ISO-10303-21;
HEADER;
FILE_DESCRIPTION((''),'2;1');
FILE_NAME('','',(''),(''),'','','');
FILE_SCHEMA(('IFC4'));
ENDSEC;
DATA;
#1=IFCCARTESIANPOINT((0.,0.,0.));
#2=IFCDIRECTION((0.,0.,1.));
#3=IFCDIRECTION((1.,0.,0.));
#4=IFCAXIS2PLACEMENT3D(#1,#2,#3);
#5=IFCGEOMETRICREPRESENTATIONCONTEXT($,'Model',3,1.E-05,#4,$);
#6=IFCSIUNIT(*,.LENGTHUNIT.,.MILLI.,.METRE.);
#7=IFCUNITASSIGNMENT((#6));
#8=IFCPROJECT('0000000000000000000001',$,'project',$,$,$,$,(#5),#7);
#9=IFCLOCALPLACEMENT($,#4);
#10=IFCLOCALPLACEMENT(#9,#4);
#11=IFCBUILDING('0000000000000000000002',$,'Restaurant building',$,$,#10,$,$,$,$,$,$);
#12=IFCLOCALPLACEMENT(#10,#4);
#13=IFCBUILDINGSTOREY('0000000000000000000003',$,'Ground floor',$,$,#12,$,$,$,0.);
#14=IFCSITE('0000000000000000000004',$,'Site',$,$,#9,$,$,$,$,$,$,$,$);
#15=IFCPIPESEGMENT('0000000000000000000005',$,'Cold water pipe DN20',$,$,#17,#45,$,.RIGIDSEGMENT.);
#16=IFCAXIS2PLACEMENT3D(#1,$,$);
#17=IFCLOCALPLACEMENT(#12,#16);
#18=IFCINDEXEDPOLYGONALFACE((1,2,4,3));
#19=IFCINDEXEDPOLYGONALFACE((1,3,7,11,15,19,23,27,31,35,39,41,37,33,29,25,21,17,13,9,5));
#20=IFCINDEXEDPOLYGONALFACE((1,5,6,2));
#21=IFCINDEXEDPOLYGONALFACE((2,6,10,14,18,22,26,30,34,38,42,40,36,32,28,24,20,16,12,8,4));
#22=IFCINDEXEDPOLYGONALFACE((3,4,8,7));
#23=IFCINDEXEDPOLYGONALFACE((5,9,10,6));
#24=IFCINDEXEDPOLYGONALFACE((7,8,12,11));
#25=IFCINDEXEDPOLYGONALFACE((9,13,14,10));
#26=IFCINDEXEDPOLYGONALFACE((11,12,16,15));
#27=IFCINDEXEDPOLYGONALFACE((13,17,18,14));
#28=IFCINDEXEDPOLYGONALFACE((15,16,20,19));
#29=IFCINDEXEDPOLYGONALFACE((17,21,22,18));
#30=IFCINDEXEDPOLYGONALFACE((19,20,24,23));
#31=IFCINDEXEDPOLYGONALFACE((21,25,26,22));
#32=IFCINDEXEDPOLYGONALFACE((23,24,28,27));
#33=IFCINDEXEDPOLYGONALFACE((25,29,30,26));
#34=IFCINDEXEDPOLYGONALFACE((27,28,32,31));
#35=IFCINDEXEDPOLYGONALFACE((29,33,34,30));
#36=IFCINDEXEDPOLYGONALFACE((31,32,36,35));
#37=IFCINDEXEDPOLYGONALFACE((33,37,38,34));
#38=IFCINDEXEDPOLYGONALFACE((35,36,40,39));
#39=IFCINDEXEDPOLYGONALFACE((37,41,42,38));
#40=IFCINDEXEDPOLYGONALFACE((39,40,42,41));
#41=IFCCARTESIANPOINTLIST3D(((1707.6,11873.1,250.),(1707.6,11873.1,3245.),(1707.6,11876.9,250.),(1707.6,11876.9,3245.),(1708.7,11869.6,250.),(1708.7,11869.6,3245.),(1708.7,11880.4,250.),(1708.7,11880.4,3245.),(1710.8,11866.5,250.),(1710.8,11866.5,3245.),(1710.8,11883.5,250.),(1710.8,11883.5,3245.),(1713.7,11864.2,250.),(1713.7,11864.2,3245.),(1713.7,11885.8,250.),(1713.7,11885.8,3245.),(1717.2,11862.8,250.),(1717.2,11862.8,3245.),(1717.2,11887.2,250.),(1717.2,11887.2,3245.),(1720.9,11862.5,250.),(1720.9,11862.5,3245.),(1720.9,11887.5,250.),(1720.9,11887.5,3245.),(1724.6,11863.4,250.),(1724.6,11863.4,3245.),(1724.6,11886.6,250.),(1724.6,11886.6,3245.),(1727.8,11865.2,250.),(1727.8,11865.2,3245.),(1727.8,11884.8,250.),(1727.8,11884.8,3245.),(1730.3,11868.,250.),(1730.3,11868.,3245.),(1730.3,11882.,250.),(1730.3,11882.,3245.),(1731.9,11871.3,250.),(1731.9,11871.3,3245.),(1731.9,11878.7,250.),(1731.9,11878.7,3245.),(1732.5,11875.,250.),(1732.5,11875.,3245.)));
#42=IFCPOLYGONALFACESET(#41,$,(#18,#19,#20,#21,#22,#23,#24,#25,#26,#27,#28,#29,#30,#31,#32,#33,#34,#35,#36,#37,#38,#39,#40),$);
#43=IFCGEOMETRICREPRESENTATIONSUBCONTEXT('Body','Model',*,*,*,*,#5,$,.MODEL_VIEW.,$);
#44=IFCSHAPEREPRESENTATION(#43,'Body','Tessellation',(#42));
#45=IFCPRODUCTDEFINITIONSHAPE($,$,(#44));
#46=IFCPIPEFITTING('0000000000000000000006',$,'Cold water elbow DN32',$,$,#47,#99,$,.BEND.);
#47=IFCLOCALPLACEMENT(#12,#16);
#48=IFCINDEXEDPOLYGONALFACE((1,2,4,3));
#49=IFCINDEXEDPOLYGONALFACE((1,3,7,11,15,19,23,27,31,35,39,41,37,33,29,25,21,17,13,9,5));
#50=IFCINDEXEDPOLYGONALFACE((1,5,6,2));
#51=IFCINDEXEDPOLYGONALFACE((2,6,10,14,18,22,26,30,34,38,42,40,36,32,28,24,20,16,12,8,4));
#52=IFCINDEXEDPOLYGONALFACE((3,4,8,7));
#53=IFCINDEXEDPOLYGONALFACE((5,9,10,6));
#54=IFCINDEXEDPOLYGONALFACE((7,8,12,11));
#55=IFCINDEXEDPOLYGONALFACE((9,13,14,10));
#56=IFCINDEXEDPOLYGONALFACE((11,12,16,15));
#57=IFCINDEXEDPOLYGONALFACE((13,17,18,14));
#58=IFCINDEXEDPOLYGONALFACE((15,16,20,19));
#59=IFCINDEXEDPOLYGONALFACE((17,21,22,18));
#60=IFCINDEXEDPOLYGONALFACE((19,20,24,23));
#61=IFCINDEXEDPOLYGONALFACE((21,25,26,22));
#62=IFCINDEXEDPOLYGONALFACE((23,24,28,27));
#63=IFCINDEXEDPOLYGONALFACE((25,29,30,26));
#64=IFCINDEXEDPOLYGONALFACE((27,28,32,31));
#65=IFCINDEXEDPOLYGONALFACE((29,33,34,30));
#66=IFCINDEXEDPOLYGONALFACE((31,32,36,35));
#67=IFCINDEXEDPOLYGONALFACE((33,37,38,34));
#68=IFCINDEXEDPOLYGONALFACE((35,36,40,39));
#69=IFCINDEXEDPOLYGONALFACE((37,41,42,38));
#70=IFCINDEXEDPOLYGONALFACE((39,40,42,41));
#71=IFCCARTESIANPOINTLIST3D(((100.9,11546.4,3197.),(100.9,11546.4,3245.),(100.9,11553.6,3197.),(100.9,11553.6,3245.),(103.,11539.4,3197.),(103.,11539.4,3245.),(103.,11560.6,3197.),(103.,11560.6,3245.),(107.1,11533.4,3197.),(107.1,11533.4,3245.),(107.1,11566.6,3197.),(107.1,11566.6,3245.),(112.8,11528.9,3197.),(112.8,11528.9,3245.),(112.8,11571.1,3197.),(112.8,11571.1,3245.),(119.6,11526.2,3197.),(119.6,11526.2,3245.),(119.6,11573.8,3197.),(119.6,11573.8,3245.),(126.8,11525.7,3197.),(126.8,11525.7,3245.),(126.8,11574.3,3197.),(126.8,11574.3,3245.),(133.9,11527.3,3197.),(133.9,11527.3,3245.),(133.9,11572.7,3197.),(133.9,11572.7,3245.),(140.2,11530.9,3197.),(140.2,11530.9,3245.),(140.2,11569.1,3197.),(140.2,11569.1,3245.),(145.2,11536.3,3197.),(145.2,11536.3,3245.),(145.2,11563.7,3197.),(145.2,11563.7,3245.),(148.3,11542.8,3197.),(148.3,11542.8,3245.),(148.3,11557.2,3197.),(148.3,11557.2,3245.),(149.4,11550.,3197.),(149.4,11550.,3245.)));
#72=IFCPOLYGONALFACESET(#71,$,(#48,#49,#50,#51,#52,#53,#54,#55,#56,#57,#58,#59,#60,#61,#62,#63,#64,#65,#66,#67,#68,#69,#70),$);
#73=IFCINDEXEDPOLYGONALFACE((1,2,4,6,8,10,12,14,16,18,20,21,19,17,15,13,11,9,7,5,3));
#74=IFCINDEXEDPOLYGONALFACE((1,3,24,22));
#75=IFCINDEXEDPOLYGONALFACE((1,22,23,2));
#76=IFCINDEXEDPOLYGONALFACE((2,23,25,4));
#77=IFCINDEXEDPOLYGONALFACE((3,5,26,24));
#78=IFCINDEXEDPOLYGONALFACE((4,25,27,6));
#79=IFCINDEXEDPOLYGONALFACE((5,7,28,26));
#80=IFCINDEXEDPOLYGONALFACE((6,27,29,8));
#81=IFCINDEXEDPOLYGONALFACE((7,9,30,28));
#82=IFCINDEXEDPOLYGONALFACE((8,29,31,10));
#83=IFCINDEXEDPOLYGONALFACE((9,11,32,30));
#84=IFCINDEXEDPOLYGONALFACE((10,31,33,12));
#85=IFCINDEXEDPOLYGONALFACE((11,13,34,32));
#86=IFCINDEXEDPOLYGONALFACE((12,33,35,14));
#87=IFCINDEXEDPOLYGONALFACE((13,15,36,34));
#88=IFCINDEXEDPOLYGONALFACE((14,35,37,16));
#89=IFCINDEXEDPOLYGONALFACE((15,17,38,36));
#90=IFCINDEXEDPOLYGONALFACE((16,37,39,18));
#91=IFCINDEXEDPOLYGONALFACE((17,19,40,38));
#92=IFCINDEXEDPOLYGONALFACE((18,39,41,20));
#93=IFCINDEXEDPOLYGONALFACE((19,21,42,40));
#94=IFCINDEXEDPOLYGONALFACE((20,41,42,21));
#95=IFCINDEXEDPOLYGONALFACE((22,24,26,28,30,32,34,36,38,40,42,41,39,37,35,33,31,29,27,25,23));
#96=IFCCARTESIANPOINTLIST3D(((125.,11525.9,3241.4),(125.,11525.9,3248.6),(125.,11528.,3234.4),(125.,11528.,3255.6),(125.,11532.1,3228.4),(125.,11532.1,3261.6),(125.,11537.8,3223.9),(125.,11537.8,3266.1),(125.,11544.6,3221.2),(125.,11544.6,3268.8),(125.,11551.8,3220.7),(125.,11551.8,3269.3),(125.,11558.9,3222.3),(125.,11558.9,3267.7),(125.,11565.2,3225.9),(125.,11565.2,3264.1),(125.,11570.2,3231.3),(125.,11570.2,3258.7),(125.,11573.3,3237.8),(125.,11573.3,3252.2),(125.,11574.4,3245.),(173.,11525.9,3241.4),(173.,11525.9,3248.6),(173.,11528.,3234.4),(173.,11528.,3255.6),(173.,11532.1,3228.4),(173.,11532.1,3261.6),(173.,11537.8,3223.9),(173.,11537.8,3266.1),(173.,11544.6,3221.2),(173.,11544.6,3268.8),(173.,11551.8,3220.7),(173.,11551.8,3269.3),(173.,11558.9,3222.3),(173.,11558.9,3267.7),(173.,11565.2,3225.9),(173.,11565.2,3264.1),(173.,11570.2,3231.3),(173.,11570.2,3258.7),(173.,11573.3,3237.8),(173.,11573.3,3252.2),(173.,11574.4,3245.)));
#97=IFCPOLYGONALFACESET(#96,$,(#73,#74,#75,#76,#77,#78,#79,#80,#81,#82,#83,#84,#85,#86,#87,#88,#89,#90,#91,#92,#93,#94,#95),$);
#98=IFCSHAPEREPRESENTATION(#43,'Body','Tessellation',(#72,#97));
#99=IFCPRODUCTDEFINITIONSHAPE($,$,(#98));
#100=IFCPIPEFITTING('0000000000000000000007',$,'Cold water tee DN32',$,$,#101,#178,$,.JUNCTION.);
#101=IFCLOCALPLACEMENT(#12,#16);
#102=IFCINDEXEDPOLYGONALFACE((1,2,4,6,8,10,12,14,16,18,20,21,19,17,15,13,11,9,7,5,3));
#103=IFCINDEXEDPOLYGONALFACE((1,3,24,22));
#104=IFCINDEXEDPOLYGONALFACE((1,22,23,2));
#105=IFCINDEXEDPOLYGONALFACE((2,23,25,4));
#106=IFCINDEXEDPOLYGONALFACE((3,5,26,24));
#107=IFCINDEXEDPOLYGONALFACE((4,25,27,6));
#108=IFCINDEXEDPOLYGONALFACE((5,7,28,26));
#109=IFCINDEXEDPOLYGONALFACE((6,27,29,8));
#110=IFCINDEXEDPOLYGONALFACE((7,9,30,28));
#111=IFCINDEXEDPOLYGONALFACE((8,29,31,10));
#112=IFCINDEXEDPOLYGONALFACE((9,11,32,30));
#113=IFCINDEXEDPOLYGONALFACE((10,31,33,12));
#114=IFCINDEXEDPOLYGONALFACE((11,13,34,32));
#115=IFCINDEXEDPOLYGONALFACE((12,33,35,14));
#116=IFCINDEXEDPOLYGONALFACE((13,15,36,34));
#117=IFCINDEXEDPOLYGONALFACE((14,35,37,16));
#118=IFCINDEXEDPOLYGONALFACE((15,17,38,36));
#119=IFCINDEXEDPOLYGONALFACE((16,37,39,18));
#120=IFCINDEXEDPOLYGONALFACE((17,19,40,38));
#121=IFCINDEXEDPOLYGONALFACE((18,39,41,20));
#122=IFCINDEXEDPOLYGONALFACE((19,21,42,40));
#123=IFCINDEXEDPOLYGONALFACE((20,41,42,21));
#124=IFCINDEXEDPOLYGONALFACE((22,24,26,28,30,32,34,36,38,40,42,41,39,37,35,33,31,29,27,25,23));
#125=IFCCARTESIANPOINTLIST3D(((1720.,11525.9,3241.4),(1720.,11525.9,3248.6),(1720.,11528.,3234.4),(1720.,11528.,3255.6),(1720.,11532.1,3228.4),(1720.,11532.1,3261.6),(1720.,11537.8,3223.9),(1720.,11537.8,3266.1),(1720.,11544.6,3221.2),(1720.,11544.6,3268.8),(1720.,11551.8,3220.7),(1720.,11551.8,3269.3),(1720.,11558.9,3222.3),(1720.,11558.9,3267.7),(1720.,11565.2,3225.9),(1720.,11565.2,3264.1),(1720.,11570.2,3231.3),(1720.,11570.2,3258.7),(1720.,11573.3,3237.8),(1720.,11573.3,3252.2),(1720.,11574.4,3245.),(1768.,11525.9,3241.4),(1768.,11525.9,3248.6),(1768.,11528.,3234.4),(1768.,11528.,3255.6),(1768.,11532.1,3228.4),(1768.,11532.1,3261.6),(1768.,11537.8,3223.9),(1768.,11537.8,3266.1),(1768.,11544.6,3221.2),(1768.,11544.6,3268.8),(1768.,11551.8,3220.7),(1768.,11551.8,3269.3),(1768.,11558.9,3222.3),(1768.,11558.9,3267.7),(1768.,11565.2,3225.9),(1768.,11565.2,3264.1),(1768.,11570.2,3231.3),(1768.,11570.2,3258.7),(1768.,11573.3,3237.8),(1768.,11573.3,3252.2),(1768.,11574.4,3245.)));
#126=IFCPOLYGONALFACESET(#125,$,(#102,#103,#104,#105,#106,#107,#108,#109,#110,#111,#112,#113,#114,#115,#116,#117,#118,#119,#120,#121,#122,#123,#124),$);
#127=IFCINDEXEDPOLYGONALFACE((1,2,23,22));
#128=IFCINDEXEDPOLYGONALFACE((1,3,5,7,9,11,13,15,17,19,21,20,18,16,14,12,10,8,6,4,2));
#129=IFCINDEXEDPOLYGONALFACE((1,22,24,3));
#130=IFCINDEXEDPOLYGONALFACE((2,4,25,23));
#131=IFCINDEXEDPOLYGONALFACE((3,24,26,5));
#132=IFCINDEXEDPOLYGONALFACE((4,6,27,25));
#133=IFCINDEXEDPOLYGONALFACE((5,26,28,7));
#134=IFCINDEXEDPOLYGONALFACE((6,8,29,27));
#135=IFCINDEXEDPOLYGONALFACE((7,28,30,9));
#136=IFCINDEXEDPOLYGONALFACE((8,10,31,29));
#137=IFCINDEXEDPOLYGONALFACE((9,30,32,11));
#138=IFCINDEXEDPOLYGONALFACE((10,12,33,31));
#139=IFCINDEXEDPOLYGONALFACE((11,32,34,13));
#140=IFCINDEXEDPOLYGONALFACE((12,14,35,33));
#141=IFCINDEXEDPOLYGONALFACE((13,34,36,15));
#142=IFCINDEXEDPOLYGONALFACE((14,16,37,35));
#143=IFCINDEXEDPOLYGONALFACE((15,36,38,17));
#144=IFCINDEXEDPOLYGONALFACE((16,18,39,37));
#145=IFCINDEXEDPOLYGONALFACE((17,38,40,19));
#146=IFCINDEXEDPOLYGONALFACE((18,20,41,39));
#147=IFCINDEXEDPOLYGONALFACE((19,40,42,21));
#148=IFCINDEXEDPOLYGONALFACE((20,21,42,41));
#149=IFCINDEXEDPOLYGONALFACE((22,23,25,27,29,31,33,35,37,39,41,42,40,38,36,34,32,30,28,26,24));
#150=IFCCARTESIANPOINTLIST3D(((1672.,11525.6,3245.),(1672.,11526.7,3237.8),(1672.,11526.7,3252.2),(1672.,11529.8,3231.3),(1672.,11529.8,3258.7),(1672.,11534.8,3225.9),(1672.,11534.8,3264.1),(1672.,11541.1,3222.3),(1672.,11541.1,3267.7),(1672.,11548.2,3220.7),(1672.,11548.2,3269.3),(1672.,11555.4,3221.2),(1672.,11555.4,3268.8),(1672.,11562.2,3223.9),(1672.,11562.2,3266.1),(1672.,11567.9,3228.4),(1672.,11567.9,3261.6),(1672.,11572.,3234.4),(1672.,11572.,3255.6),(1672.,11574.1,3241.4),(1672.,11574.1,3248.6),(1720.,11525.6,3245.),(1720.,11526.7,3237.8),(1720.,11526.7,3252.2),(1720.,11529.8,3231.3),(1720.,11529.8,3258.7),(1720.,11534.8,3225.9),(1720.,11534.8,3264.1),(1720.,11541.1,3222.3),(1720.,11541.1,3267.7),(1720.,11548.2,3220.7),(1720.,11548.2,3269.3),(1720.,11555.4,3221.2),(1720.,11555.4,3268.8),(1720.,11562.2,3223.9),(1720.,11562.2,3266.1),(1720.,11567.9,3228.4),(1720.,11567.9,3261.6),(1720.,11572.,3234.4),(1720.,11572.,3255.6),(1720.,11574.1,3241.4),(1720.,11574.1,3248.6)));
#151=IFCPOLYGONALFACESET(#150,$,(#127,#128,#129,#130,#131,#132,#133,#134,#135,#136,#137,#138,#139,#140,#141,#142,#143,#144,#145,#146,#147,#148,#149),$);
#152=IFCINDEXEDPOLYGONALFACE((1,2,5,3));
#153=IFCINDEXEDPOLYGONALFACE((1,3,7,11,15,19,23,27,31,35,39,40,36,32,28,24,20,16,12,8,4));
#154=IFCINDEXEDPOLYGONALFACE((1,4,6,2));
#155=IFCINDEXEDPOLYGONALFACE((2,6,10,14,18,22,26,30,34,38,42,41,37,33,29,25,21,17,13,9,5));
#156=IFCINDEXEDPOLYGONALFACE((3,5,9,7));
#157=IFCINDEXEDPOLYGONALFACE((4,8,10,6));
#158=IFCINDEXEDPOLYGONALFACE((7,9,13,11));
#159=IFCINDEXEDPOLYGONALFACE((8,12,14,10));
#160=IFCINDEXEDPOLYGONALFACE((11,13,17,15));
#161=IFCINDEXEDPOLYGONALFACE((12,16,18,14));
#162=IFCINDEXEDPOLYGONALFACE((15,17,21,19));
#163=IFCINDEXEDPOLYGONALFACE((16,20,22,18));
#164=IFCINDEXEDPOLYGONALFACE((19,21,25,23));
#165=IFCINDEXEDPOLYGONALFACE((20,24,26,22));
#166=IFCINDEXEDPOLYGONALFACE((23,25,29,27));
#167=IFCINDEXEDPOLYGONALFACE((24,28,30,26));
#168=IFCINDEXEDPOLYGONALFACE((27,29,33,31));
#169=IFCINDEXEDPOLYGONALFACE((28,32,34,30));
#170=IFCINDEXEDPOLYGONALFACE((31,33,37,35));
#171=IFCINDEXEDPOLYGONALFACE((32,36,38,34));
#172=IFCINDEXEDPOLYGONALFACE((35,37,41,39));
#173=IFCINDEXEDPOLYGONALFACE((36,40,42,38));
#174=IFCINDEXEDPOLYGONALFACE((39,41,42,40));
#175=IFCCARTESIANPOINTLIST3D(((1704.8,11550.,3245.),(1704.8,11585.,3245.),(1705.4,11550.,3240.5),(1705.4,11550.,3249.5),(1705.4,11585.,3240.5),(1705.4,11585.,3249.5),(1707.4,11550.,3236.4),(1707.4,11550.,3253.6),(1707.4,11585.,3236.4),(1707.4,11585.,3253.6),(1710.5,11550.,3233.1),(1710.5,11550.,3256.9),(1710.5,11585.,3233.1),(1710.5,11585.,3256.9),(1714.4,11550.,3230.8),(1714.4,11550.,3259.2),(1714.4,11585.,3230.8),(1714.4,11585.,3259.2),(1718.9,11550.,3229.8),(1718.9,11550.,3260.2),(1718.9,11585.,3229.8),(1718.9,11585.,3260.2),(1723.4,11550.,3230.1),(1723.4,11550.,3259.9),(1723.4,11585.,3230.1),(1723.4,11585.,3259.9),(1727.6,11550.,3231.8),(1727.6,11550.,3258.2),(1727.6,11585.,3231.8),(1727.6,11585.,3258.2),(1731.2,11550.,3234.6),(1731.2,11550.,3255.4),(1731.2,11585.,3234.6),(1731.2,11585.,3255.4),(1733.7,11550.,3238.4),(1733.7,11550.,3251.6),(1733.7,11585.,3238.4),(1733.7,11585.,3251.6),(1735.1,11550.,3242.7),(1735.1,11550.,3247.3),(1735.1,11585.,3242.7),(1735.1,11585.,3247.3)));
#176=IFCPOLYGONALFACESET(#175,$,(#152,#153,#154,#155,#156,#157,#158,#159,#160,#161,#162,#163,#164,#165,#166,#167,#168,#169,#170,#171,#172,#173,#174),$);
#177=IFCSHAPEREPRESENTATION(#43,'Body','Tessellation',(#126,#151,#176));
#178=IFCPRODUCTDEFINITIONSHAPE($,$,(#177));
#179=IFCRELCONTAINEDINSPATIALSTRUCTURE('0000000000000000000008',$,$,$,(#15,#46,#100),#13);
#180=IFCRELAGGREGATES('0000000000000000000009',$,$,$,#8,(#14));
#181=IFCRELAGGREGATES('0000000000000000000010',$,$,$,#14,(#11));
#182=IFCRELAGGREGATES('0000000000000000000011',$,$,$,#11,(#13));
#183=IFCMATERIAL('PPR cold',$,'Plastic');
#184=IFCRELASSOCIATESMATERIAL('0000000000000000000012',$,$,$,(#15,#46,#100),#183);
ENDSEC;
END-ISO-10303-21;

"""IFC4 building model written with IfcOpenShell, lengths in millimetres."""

from ifc_helpers import new_model, si_unit, frame, origin_with_axes, origin_2d, place, context, subcontext, project, spatial, circle, extrude, material, element, save


model = new_model("IFC4")

# Units and contexts
model_context = context("Model", 3, precision=1e-05, world=origin_with_axes())
body_context = subcontext(model_context, "Body", "Model", "MODEL_VIEW")
ifc_project = project(units=[si_unit("LENGTHUNIT", "METRE", prefix="MILLI")], contexts=[model_context])

# Site, building, storey
site_placement = place(None, origin_with_axes())
site = spatial("IfcSite", under=ifc_project, at=site_placement, Name="Site")
building_placement = place(site_placement, origin_with_axes())
building = spatial("IfcBuilding", under=site, at=building_placement, Name="Restaurant building")
storey_placement = place(building_placement, origin_with_axes())
storey = spatial("IfcBuildingStorey", under=building, at=storey_placement, Name="Ground floor", Elevation=0.0)

# Pipe segment
ifc_material_1 = material(Name="PPR cold", Category="Plastic")
pipe_segment_1_placement = place(storey_placement, frame((1720.0, 11875.0, 3245.0)))
element("IfcPipeSegment", 1, at=pipe_segment_1_placement, inside=storey, material=ifc_material_1, Name="Cold water pipe DN20", PredefinedType="RIGIDSEGMENT", context=body_context, shape_type="SweptSolid", body=[
    extrude(circle(Radius=12.5, at=origin_2d()), frame((0.0, 0.0, 0.0), z_axis=(0.0, 0.0, -1.0), x_axis=(1.0, 0.0, 0.0)), (0.0, 0.0, 1.0), 2995.0),
])

# Pipe fittings
pipe_fitting_1_placement = place(storey_placement, frame((125.0, 11550.0, 3245.0)))
element("IfcPipeFitting", 2, at=pipe_fitting_1_placement, inside=storey, material=ifc_material_1, Name="Cold water elbow DN32", PredefinedType="BEND", context=body_context, shape_type="SweptSolid", body=[
    extrude(circle(Radius=24.4, at=origin_2d()), frame((0.0, 0.0, 0.0), z_axis=(0.0, 0.0, -1.0), x_axis=(1.0, 0.0, 0.0)), (0.0, 0.0, 1.0), 48.0),
    extrude(circle(Radius=24.4, at=origin_2d()), frame((0.0, 0.0, 0.0), z_axis=(1.0, 0.0, 0.0), x_axis=(0.0, 1.0, 0.0)), (0.0, 0.0, 1.0), 48.0),
])
pipe_fitting_2_placement = place(storey_placement, frame((1720.0, 11550.0, 3245.0)))
element("IfcPipeFitting", 3, at=pipe_fitting_2_placement, inside=storey, material=ifc_material_1, Name="Cold water tee DN32", PredefinedType="JUNCTION", context=body_context, shape_type="SweptSolid", body=[
    extrude(circle(Radius=24.4, at=origin_2d()), frame((0.0, 0.0, 0.0), z_axis=(1.0, 0.0, 0.0), x_axis=(0.0, 1.0, 0.0)), (0.0, 0.0, 1.0), 48.0),
    extrude(circle(Radius=24.4, at=origin_2d()), frame((0.0, 0.0, 0.0), z_axis=(-1.0, 0.0, 0.0), x_axis=(0.0, -1.0, 0.0)), (0.0, 0.0, 1.0), 48.0),
    extrude(circle(Radius=15.2, at=origin_2d()), frame((0.0, 0.0, 0.0), z_axis=(0.0, 1.0, 0.0), x_axis=(-1.0, 0.0, 0.0)), (0.0, 0.0, 1.0), 35.0),
])

save(model, "model.ifc")
